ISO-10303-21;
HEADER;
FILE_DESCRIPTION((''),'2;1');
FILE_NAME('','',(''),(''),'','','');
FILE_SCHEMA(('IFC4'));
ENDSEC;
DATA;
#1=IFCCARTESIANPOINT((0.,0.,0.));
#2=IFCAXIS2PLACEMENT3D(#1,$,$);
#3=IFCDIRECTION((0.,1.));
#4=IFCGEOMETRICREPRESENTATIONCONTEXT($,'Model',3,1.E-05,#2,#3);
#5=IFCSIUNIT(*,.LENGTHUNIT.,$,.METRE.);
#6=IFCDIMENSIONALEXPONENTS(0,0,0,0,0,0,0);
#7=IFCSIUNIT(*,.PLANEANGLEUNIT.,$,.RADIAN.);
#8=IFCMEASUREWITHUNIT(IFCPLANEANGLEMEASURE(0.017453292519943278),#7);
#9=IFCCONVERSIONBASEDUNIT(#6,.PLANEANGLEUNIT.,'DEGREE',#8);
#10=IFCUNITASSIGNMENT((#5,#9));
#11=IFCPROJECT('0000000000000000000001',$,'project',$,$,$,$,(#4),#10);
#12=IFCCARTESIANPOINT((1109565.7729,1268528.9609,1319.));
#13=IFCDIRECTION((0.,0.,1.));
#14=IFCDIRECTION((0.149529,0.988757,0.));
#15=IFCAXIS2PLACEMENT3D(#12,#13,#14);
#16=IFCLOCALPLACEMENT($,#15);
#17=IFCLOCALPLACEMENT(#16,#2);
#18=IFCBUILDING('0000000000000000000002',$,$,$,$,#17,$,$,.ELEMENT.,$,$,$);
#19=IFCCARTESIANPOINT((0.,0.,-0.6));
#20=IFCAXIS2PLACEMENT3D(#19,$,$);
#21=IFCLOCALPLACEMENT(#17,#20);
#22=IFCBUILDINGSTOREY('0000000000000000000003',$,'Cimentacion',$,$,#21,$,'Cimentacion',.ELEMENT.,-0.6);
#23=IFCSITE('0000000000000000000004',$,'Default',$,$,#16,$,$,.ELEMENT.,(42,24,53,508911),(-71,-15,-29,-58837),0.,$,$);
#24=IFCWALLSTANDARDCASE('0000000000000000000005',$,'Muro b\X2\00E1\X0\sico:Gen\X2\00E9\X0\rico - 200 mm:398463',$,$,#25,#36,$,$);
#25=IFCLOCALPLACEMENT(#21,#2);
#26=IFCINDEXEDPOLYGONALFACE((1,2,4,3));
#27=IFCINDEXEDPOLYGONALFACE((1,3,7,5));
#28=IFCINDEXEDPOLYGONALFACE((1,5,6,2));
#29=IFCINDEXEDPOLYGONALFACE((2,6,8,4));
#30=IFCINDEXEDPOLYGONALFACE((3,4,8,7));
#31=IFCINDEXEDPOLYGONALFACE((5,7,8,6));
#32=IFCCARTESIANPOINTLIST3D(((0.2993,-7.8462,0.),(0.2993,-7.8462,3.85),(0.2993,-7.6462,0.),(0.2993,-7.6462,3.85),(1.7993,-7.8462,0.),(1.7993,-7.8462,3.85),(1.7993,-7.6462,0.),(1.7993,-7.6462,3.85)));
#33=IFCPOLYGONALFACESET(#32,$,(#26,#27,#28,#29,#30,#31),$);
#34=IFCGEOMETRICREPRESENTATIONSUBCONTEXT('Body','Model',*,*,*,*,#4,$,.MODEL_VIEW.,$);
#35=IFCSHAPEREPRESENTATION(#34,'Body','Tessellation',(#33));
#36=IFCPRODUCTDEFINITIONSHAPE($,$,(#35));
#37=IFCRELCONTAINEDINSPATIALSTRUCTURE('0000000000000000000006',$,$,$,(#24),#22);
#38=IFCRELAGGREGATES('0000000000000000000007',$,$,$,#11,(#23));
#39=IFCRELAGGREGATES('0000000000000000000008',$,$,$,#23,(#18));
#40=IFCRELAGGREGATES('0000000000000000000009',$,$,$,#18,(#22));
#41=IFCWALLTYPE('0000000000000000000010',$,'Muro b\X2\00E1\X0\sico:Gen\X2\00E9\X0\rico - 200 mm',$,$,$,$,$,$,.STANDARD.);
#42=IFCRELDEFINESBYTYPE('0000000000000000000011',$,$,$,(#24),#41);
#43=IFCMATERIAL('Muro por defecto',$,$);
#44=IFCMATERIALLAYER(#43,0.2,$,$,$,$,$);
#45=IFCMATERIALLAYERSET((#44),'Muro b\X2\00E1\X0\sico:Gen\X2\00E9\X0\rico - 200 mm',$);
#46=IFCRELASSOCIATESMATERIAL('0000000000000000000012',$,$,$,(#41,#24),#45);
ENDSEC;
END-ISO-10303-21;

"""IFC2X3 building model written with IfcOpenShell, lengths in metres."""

from ifc_helpers import new_model, entity, si_unit, converted_unit, direction, frame, frame_2d, origin, place, context, subcontext, project, spatial, rectangle, extrude, material, layer, layer_set, layer_usage, type_object, element, save


model = new_model("IFC2X3")

# Units and contexts
model_context = context("Model", 3, precision=1e-05, world=origin(), true_north=direction((0.0, 1.0)))
body_context = subcontext(model_context, "Body", "Model", "MODEL_VIEW")
ifc_project = project(units=[si_unit("LENGTHUNIT", "METRE"), converted_unit("PLANEANGLEUNIT", "DEGREE", entity("IfcPlaneAngleMeasure", 0.017453292519943278), si_unit("PLANEANGLEUNIT", "RADIAN"), dimensions=[0, 0, 0, 0, 0, 0, 0])], contexts=[model_context])

# Site, building, storey
site_placement = place(None, frame((1109565.7729, 1268528.9609, 1319.0), z_axis=(0.0, 0.0, 1.0), x_axis=(0.149529, 0.988757, 0.0)))
site = spatial("IfcSite", under=ifc_project, at=site_placement, Name="Default", CompositionType="ELEMENT", RefLatitude=(42, 24, 53, 508911), RefLongitude=(-71, -15, -29, -58837), RefElevation=0.0)
building_placement = place(site_placement, origin())
building = spatial("IfcBuilding", under=site, at=building_placement, CompositionType="ELEMENT")
storey_placement = place(building_placement, frame((0.0, 0.0, -0.6)))
storey = spatial("IfcBuildingStorey", under=building, at=storey_placement, Name="Cimentacion", LongName="Cimentacion", CompositionType="ELEMENT", Elevation=-0.6)

# Wall
ifc_material_1 = material(Name="Muro por defecto")
ifc_layer_1 = layer(ifc_material_1, 0.2)
ifc_layer_set_1 = layer_set([ifc_layer_1], Name="Muro básico:Genérico - 200 mm")
ifc_layer_usage_1 = layer_usage(ifc_layer_set_1, "AXIS2", "NEGATIVE", 0.1)
wall_type = type_object("IfcWallType", Name="Muro básico:Genérico - 200 mm", PredefinedType="STANDARD", material=ifc_layer_set_1)
wall_placement = place(storey_placement, frame((0.2993, -7.7462, 0.0)))
element("IfcWallStandardCase", 1, at=wall_placement, inside=storey, type_object=wall_type, material=ifc_layer_usage_1, Name="Muro básico:Genérico - 200 mm:398463", context=body_context, shape_type="SweptSolid", body=[
    extrude(rectangle(XDim=1.5, YDim=0.2, at=frame_2d((0.75, 0.0), x_axis=(-1.0, 0.0))), origin(), (0.0, 0.0, 1.0), 3.85),
])

save(model, "model.ifc")
